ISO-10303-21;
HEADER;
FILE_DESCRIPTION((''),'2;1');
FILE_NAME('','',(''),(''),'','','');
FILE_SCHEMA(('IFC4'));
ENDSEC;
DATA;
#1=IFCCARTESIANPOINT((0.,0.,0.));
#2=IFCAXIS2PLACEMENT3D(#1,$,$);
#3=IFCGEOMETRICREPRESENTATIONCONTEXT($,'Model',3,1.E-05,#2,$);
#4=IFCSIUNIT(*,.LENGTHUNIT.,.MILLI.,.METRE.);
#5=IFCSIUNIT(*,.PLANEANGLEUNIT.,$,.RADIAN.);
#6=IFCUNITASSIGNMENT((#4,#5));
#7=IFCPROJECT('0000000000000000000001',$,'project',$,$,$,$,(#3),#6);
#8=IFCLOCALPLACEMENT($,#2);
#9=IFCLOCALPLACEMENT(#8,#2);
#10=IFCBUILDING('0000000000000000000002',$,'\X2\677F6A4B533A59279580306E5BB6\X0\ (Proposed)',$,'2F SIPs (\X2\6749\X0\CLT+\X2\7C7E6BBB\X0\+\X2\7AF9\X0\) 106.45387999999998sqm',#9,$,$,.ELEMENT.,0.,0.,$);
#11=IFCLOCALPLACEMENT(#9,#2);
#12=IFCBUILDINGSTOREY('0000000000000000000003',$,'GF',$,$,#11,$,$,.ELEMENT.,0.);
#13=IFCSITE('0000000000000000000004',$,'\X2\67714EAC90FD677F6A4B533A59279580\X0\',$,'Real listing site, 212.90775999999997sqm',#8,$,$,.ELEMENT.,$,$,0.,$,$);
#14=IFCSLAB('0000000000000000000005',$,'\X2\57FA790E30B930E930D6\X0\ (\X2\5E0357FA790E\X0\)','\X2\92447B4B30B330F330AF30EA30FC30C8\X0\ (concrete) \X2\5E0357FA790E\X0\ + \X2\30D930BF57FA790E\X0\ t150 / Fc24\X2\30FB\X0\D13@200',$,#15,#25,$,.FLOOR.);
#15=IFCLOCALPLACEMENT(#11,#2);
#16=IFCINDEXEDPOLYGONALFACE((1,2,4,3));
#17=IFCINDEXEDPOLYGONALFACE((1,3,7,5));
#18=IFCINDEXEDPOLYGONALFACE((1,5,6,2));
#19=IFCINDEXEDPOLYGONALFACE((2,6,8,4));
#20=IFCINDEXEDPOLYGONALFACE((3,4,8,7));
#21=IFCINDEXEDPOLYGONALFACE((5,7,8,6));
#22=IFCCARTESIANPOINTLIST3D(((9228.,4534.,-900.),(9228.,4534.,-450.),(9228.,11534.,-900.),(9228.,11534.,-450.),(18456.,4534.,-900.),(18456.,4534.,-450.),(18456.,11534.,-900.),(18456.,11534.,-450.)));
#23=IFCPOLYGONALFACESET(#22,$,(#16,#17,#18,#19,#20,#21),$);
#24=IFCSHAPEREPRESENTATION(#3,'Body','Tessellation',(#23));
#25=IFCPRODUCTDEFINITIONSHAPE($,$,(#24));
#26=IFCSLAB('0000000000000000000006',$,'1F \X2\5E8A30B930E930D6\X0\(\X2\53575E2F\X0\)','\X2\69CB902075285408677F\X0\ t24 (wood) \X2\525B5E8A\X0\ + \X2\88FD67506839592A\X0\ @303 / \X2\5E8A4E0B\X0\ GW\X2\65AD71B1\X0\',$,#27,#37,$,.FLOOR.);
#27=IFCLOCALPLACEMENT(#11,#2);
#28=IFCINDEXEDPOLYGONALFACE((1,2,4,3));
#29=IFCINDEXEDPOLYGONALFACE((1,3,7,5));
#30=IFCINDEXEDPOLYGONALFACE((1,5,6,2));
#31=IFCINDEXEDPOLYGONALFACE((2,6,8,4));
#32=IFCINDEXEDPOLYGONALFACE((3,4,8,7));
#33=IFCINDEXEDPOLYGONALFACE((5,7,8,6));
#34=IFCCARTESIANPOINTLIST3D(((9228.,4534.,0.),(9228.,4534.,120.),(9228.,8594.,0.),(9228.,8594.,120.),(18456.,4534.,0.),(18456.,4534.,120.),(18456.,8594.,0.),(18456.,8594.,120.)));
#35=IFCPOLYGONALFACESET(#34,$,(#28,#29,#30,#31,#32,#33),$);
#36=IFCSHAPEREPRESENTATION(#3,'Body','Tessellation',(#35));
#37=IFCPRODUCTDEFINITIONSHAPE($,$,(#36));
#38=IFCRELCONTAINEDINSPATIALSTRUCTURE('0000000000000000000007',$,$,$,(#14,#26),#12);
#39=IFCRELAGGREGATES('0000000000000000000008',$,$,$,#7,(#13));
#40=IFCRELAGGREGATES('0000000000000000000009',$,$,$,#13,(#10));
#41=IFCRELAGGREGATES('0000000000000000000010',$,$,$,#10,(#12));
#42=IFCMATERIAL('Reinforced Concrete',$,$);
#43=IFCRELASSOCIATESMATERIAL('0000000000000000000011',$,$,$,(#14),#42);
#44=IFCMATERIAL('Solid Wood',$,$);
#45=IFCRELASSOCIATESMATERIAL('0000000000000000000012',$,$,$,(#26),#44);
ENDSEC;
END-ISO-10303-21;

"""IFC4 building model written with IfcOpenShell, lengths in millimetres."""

from ifc_helpers import new_model, si_unit, frame, frame_2d, origin, place, context, project, spatial, rectangle, extrude, material, element, save


model = new_model("IFC4")

# Units and contexts
model_context = context("Model", 3, precision=1e-05, world=origin())
ifc_project = project(units=[si_unit("LENGTHUNIT", "METRE", prefix="MILLI"), si_unit("PLANEANGLEUNIT", "RADIAN")], contexts=[model_context])

# Site, building, storey
site_placement = place(None, origin())
site = spatial("IfcSite", under=ifc_project, at=site_placement, Name="東京都板橋区大門", ObjectType="Real listing site, 212.90775999999997sqm", CompositionType="ELEMENT", RefElevation=0.0)
building_placement = place(site_placement, origin())
building = spatial("IfcBuilding", under=site, at=building_placement, Name="板橋区大門の家 (Proposed)", ObjectType="2F SIPs (杉CLT+籾殻+竹) 106.45387999999998sqm", CompositionType="ELEMENT", ElevationOfRefHeight=0.0, ElevationOfTerrain=0.0)
storey_placement = place(building_placement, origin())
storey = spatial("IfcBuildingStorey", under=building, at=storey_placement, Name="GF", CompositionType="ELEMENT", Elevation=0.0)

# Slabs
ifc_material_1 = material(Name="Reinforced Concrete")
slab_1_placement = place(storey_placement, frame((4614.0, 2267.0, -450.0)))
element("IfcSlab", 1, at=slab_1_placement, inside=storey, material=ifc_material_1, Name="基礎スラブ (布基礎)", Description="鉄筋コンクリート (concrete) 布基礎 + ベタ基礎 t150 / Fc24・D13@200", PredefinedType="FLOOR", context=model_context, shape_type="SweptSolid", body=[
    extrude(rectangle(XDim=9228.0, YDim=7000.0, at=frame_2d((4614.0, 3500.0))), frame((4614.0, 2267.0, -450.0)), (0.0, 0.0, 1.0), 450.0),
])
ifc_material_2 = material(Name="Solid Wood")
slab_2_placement = place(storey_placement, frame((4614.0, 2267.0, 0.0)))
element("IfcSlab", 2, at=slab_2_placement, inside=storey, material=ifc_material_2, Name="1F 床スラブ(南帯)", Description="構造用合板 t24 (wood) 剛床 + 製材根太 @303 / 床下 GW断熱", PredefinedType="FLOOR", context=model_context, shape_type="SweptSolid", body=[
    extrude(rectangle(XDim=9228.0, YDim=4060.0, at=frame_2d((4614.0, 2030.0))), frame((4614.0, 2267.0, 0.0)), (0.0, 0.0, 1.0), 120.0),
])

save(model, "model.ifc")
